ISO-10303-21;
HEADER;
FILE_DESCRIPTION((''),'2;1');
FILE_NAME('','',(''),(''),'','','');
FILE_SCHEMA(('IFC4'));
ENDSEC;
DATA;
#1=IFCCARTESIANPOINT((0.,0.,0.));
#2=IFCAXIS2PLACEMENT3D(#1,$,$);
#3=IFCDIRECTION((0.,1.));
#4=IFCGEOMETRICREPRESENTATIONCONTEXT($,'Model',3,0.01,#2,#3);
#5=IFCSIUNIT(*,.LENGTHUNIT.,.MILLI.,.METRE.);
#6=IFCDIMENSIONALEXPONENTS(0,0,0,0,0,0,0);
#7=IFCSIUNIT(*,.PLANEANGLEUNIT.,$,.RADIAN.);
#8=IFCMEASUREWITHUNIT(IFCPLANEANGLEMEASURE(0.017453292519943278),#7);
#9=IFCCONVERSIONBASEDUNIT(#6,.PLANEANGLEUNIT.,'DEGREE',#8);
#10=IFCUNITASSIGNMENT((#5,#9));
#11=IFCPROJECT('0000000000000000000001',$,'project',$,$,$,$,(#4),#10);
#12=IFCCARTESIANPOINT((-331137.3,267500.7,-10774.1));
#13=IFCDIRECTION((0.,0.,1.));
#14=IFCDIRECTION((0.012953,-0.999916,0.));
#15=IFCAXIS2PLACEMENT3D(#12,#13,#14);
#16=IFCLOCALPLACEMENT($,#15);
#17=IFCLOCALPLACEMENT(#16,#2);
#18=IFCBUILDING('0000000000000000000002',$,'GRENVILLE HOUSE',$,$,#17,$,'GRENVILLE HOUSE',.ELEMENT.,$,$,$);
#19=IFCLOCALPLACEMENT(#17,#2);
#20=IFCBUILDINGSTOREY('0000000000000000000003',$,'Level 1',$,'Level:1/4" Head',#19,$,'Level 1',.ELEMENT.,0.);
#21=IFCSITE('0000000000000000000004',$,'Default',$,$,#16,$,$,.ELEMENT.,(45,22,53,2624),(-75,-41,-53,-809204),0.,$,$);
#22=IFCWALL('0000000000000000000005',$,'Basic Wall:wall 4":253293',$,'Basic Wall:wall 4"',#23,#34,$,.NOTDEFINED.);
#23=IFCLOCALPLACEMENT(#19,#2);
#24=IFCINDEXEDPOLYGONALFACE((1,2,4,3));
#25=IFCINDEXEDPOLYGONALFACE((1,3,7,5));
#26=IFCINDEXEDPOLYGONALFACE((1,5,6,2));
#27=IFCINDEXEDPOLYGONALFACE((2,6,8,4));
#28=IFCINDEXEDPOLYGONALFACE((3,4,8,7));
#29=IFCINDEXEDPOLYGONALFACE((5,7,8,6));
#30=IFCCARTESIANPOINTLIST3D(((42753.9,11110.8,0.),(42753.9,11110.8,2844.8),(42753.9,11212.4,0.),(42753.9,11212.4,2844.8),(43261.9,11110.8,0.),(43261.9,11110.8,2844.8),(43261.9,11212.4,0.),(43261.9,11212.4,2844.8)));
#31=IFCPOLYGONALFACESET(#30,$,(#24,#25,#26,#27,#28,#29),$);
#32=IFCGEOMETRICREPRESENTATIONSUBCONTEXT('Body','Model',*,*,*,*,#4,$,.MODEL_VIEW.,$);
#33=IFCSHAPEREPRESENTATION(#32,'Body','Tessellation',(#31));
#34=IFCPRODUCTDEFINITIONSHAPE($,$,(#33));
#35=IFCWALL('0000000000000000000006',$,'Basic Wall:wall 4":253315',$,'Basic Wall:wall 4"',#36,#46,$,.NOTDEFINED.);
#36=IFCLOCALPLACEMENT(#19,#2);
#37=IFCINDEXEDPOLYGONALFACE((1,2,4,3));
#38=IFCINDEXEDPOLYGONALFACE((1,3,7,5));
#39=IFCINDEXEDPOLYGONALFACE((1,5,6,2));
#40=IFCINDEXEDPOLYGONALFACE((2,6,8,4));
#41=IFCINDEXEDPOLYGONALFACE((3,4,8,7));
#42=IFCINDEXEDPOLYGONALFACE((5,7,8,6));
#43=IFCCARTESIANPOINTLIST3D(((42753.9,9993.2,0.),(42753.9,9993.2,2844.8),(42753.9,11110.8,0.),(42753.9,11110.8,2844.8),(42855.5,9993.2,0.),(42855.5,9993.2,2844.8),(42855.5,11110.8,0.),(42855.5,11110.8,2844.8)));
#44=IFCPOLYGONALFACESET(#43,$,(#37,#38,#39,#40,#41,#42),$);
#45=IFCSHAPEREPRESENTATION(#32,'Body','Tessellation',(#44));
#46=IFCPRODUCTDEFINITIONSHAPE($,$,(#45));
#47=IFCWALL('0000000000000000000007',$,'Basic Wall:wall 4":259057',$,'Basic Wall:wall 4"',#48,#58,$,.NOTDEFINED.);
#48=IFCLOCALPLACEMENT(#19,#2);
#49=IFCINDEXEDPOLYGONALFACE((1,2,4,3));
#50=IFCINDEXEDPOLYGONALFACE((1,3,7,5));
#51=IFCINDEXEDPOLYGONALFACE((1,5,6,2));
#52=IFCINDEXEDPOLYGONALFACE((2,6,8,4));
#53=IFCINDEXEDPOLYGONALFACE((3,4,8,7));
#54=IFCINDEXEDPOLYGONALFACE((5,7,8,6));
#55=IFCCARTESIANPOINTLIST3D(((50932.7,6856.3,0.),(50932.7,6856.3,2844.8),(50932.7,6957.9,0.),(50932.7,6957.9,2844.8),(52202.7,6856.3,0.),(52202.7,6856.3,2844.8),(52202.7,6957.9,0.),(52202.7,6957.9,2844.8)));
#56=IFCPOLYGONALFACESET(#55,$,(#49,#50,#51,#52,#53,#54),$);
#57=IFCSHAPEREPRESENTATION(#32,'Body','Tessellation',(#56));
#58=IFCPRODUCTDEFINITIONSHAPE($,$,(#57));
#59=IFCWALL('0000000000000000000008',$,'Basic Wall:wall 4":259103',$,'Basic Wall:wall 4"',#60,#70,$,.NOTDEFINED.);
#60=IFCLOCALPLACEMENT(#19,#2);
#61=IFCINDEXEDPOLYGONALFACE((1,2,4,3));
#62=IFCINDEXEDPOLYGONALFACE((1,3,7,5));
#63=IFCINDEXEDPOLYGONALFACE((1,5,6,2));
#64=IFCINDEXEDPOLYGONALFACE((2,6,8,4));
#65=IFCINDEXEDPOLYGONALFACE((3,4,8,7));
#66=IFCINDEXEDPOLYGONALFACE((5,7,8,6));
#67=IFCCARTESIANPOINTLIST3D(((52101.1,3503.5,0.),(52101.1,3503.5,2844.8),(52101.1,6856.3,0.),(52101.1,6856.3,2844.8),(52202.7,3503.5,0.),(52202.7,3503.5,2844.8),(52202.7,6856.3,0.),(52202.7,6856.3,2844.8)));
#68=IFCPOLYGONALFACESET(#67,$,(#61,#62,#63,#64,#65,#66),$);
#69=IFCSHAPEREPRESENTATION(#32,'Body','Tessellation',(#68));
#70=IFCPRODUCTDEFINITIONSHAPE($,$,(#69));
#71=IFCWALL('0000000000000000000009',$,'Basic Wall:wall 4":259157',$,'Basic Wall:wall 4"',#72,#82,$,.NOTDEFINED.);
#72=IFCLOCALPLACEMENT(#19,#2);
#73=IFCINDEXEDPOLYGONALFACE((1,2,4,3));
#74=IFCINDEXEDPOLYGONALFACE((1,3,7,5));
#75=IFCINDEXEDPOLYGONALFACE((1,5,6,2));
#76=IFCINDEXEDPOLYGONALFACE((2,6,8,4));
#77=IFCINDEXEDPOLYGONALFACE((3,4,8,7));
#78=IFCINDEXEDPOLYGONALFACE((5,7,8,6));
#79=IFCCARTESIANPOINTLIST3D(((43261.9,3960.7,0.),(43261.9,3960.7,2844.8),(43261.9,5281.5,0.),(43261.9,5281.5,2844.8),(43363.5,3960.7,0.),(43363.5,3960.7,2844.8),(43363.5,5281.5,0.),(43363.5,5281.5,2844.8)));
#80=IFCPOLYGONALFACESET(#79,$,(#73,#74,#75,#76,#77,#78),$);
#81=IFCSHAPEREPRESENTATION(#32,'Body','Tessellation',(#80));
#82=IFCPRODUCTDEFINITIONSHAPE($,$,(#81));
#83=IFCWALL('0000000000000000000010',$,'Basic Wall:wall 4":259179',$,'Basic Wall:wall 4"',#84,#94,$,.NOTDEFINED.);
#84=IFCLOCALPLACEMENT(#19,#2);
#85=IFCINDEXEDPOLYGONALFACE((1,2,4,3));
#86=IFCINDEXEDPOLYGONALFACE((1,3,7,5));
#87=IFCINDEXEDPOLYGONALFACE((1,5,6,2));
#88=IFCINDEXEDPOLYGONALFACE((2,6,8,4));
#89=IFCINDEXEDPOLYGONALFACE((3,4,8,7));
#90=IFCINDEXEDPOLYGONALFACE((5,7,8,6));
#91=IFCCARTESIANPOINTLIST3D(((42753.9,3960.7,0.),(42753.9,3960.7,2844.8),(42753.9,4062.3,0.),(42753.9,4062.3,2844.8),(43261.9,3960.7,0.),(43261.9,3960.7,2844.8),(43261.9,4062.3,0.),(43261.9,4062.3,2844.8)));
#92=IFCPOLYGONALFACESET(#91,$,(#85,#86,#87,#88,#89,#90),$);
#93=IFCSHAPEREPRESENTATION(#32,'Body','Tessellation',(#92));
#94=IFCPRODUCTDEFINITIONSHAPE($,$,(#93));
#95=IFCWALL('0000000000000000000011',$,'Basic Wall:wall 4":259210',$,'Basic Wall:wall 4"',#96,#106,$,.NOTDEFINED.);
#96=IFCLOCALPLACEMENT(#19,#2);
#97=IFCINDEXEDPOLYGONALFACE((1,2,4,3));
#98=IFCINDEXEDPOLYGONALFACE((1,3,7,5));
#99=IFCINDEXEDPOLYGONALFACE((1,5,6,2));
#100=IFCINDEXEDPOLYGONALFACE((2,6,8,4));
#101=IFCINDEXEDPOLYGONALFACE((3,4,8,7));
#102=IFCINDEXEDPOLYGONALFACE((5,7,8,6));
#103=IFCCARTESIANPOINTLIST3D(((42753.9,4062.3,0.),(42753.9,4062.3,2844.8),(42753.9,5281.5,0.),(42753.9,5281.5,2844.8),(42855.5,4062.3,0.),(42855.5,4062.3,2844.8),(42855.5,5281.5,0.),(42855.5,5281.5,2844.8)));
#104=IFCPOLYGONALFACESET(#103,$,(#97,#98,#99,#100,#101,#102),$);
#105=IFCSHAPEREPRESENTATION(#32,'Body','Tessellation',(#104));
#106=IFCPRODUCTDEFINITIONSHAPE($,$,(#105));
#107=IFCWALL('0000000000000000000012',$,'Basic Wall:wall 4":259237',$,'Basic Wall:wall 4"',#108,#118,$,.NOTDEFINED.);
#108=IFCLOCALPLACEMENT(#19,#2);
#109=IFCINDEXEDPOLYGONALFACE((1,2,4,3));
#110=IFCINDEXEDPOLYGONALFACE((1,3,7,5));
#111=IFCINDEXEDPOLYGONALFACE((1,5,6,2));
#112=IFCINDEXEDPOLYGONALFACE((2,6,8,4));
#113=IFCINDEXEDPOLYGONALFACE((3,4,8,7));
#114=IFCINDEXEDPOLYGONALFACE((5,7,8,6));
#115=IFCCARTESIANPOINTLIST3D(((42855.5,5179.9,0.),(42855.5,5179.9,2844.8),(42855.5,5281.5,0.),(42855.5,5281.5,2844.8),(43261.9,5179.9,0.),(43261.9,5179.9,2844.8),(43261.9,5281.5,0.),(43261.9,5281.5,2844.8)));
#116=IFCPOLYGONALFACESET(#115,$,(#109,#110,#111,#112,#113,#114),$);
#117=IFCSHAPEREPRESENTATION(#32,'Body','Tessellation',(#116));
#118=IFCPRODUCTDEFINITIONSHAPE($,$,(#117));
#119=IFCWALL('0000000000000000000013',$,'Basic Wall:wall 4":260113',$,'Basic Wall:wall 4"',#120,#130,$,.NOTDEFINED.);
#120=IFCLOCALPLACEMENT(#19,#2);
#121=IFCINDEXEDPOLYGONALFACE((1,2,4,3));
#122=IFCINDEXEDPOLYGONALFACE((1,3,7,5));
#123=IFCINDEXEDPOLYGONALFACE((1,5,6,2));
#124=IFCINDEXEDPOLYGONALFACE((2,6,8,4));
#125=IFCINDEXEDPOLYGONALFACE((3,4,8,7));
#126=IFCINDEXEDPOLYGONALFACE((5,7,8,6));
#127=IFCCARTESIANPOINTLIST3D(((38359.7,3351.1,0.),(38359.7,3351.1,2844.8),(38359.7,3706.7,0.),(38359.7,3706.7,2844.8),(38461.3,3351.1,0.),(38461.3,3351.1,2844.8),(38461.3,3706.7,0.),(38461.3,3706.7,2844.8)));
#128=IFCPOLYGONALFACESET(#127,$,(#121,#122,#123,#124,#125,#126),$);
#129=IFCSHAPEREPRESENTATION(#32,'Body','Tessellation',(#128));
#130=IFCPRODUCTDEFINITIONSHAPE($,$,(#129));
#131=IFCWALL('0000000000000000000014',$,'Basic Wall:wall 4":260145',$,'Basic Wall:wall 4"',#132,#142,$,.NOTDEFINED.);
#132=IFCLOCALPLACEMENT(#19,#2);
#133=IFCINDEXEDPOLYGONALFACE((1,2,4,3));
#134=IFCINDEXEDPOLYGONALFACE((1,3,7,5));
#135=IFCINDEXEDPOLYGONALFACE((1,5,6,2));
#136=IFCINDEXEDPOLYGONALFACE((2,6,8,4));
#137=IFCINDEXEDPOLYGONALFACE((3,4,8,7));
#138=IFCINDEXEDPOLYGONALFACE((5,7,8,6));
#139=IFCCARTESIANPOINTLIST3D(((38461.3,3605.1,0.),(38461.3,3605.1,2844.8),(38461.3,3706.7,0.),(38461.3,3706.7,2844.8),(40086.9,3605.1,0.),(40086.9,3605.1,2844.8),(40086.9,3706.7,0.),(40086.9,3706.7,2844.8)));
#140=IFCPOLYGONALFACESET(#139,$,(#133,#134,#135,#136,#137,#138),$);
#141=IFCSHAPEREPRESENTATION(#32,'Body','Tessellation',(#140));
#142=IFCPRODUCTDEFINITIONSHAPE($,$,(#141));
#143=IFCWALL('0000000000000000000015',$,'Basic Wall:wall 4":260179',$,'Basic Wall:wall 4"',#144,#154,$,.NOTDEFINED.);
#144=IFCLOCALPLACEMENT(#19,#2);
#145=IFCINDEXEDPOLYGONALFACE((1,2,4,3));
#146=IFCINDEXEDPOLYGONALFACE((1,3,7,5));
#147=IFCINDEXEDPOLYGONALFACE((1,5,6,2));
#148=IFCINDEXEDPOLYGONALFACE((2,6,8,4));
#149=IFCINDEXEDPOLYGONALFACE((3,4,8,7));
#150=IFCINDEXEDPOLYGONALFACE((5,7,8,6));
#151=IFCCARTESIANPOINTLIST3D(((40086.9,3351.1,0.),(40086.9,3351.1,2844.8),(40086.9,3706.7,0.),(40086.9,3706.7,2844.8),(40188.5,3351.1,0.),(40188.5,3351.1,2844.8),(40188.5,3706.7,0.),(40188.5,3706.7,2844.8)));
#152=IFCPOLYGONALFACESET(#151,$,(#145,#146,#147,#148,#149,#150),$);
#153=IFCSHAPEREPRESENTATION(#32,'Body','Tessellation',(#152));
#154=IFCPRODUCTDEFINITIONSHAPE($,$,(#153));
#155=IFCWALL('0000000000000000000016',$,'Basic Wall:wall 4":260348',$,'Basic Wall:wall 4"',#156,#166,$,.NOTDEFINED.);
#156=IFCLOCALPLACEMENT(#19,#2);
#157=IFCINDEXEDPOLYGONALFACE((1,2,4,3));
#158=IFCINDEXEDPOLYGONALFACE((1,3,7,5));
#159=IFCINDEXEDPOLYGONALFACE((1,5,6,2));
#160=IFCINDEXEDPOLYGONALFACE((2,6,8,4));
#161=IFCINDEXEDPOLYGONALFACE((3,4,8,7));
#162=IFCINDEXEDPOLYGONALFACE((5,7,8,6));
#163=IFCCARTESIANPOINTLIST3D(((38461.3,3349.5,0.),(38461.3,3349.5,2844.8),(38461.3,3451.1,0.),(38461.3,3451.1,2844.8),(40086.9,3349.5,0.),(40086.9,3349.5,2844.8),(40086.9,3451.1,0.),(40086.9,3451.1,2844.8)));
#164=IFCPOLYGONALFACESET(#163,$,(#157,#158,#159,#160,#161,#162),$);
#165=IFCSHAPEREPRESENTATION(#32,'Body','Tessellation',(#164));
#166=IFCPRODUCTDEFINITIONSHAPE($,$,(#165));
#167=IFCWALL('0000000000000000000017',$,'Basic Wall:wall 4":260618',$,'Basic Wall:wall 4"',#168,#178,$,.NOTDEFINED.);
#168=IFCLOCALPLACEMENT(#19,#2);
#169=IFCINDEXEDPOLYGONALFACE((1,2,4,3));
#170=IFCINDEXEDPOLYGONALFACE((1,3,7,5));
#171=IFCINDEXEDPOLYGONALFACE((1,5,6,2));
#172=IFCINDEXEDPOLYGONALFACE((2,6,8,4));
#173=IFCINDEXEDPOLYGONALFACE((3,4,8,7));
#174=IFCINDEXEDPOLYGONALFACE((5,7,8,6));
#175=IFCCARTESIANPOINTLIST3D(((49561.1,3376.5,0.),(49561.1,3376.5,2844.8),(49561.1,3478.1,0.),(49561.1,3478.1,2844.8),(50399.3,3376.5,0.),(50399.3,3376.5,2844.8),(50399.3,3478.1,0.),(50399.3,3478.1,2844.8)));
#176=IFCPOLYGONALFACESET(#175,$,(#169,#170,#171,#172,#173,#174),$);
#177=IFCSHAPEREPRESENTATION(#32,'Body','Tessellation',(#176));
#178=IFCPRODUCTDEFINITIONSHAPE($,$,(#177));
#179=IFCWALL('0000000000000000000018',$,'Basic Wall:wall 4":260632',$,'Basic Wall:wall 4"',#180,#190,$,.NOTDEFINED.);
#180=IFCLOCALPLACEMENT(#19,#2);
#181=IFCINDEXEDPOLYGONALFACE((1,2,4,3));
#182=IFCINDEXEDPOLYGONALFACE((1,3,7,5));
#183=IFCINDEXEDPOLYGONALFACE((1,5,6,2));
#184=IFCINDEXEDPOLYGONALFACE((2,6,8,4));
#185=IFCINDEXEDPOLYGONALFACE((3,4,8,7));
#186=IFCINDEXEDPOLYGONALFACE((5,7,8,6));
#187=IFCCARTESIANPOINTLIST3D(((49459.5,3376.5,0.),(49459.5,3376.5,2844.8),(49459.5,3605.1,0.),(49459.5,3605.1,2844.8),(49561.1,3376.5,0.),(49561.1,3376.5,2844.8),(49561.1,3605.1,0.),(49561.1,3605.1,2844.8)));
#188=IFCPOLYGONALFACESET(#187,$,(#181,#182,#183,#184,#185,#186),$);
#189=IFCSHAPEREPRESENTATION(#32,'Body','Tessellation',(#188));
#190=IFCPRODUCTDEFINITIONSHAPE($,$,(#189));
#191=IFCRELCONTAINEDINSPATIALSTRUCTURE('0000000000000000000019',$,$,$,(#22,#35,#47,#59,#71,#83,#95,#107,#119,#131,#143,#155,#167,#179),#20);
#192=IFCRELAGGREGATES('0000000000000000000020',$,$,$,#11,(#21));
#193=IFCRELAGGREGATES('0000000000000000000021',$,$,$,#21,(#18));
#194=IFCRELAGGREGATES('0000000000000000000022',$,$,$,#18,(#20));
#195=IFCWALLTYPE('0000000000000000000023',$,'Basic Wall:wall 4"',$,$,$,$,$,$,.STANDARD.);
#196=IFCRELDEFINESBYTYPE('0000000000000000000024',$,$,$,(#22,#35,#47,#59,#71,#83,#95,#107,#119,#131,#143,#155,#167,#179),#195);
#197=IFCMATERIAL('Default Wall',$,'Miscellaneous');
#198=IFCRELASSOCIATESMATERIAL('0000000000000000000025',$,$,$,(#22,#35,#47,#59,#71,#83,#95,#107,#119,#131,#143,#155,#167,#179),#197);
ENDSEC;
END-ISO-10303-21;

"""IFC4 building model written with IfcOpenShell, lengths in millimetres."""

from ifc_helpers import new_model, entity, si_unit, converted_unit, direction, frame, origin, place, context, subcontext, project, spatial, indexed_curve, outline, extrude, material, type_object, element, save


model = new_model("IFC4")

# Units and contexts
model_context = context("Model", 3, precision=0.01, world=origin(), true_north=direction((0.0, 1.0)))
body_context = subcontext(model_context, "Body", "Model", "MODEL_VIEW")
ifc_project = project(units=[si_unit("LENGTHUNIT", "METRE", prefix="MILLI"), converted_unit("PLANEANGLEUNIT", "DEGREE", entity("IfcPlaneAngleMeasure", 0.017453292519943278), si_unit("PLANEANGLEUNIT", "RADIAN"), dimensions=[0, 0, 0, 0, 0, 0, 0])], contexts=[model_context])

# Site, building, storey
site_placement = place(None, frame((-331137.3, 267500.7, -10774.1), z_axis=(0.0, 0.0, 1.0), x_axis=(0.012953, -0.999916, 0.0)))
site = spatial("IfcSite", under=ifc_project, at=site_placement, Name="Default", CompositionType="ELEMENT", RefLatitude=(45, 22, 53, 2624), RefLongitude=(-75, -41, -53, -809204), RefElevation=0.0)
building_placement = place(site_placement, origin())
building = spatial("IfcBuilding", under=site, at=building_placement, Name="GRENVILLE HOUSE", LongName="GRENVILLE HOUSE", CompositionType="ELEMENT")
storey_placement = place(building_placement, origin())
storey = spatial("IfcBuildingStorey", under=building, at=storey_placement, Name="Level 1", ObjectType="Level:1/4\" Head", LongName="Level 1", CompositionType="ELEMENT", Elevation=0.0)

# Walls
ifc_material_1 = material(Name="Default Wall", Category="Miscellaneous")
wall_type_1 = type_object("IfcWallType", Name="Basic Wall:wall 4\"", PredefinedType="STANDARD")
wall_1_placement = place(storey_placement, frame((43261.9, 11161.6, 0.0), z_axis=(0.0, 0.0, 1.0), x_axis=(-1.0, 0.0, 0.0)))
element("IfcWall", 1, at=wall_1_placement, inside=storey, type_object=wall_type_1, material=ifc_material_1, Name="Basic Wall:wall 4\":253293", ObjectType="Basic Wall:wall 4\"", PredefinedType="NOTDEFINED", context=body_context, shape_type="SweptSolid", body=[
    extrude(outline(indexed_curve([(508.0, 50.8), (0.0, 50.8), (0.0, -50.8), (508.0, -50.8), (508.0, 50.8)], self_intersect=False)), origin(), (0.0, 0.0, 1.0), 2844.8),
])
wall_2_placement = place(storey_placement, frame((42804.7, 11110.8, 0.0), z_axis=(0.0, 0.0, 1.0), x_axis=(0.0, -1.0, 0.0)))
element("IfcWall", 2, at=wall_2_placement, inside=storey, type_object=wall_type_1, material=ifc_material_1, Name="Basic Wall:wall 4\":253315", ObjectType="Basic Wall:wall 4\"", PredefinedType="NOTDEFINED", context=body_context, shape_type="SweptSolid", body=[
    extrude(outline(indexed_curve([(1117.6, 50.8), (0.0, 50.8), (0.0, -50.8), (1117.6, -50.8), (1117.6, 50.8)], self_intersect=False)), origin(), (0.0, 0.0, 1.0), 2844.8),
])
wall_3_placement = place(storey_placement, frame((50932.7, 6907.1, 0.0)))
element("IfcWall", 3, at=wall_3_placement, inside=storey, type_object=wall_type_1, material=ifc_material_1, Name="Basic Wall:wall 4\":259057", ObjectType="Basic Wall:wall 4\"", PredefinedType="NOTDEFINED", context=body_context, shape_type="SweptSolid", body=[
    extrude(outline(indexed_curve([(1270.0, 50.8), (0.0, 50.8), (0.0, -50.8), (1270.0, -50.8), (1270.0, 50.8)], self_intersect=False)), origin(), (0.0, 0.0, 1.0), 2844.8),
])
wall_4_placement = place(storey_placement, frame((52151.9, 6856.3, 0.0), z_axis=(0.0, 0.0, 1.0), x_axis=(0.0, -1.0, 0.0)))
element("IfcWall", 4, at=wall_4_placement, inside=storey, type_object=wall_type_1, material=ifc_material_1, Name="Basic Wall:wall 4\":259103", ObjectType="Basic Wall:wall 4\"", PredefinedType="NOTDEFINED", context=body_context, shape_type="SweptSolid", body=[
    extrude(outline(indexed_curve([(3352.8, 50.8), (0.0, 50.8), (0.0, -50.8), (3352.8, -50.8), (3352.8, 50.8)], self_intersect=False)), origin(), (0.0, 0.0, 1.0), 2844.8),
])
wall_5_placement = place(storey_placement, frame((43312.7, 5281.5, 0.0), z_axis=(0.0, 0.0, 1.0), x_axis=(0.0, -1.0, 0.0)))
element("IfcWall", 5, at=wall_5_placement, inside=storey, type_object=wall_type_1, material=ifc_material_1, Name="Basic Wall:wall 4\":259157", ObjectType="Basic Wall:wall 4\"", PredefinedType="NOTDEFINED", context=body_context, shape_type="SweptSolid", body=[
    extrude(outline(indexed_curve([(1320.8, 50.8), (0.0, 50.8), (0.0, -50.8), (1320.8, -50.8), (1320.8, 50.8)], self_intersect=False)), origin(), (0.0, 0.0, 1.0), 2844.8),
])
wall_6_placement = place(storey_placement, frame((43261.9, 4011.5, 0.0), z_axis=(0.0, 0.0, 1.0), x_axis=(-1.0, 0.0, 0.0)))
element("IfcWall", 6, at=wall_6_placement, inside=storey, type_object=wall_type_1, material=ifc_material_1, Name="Basic Wall:wall 4\":259179", ObjectType="Basic Wall:wall 4\"", PredefinedType="NOTDEFINED", context=body_context, shape_type="SweptSolid", body=[
    extrude(outline(indexed_curve([(508.0, 50.8), (0.0, 50.8), (0.0, -50.8), (508.0, -50.8), (508.0, 50.8)], self_intersect=False)), origin(), (0.0, 0.0, 1.0), 2844.8),
])
wall_7_placement = place(storey_placement, frame((42804.7, 4062.3, 0.0), z_axis=(0.0, 0.0, 1.0), x_axis=(0.0, 1.0, 0.0)))
element("IfcWall", 7, at=wall_7_placement, inside=storey, type_object=wall_type_1, material=ifc_material_1, Name="Basic Wall:wall 4\":259210", ObjectType="Basic Wall:wall 4\"", PredefinedType="NOTDEFINED", context=body_context, shape_type="SweptSolid", body=[
    extrude(outline(indexed_curve([(1219.2, 50.8), (0.0, 50.8), (0.0, -50.8), (1219.2, -50.8), (1219.2, 50.8)], self_intersect=False)), origin(), (0.0, 0.0, 1.0), 2844.8),
])
wall_8_placement = place(storey_placement, frame((42855.5, 5230.7, 0.0)))
element("IfcWall", 8, at=wall_8_placement, inside=storey, type_object=wall_type_1, material=ifc_material_1, Name="Basic Wall:wall 4\":259237", ObjectType="Basic Wall:wall 4\"", PredefinedType="NOTDEFINED", context=body_context, shape_type="SweptSolid", body=[
    extrude(outline(indexed_curve([(406.4, 50.8), (0.0, 50.8), (0.0, -50.8), (406.4, -50.8), (406.4, 50.8)], self_intersect=False)), origin(), (0.0, 0.0, 1.0), 2844.8),
])
wall_9_placement = place(storey_placement, frame((38410.5, 3351.1, 0.0), z_axis=(0.0, 0.0, 1.0), x_axis=(0.0, 1.0, 0.0)))
element("IfcWall", 9, at=wall_9_placement, inside=storey, type_object=wall_type_1, material=ifc_material_1, Name="Basic Wall:wall 4\":260113", ObjectType="Basic Wall:wall 4\"", PredefinedType="NOTDEFINED", context=body_context, shape_type="SweptSolid", body=[
    extrude(outline(indexed_curve([(355.6, 50.8), (0.0, 50.8), (0.0, -50.8), (355.6, -50.8), (355.6, 50.8)], self_intersect=False)), origin(), (0.0, 0.0, 1.0), 2844.8),
])
wall_10_placement = place(storey_placement, frame((38461.3, 3655.9, 0.0)))
element("IfcWall", 10, at=wall_10_placement, inside=storey, type_object=wall_type_1, material=ifc_material_1, Name="Basic Wall:wall 4\":260145", ObjectType="Basic Wall:wall 4\"", PredefinedType="NOTDEFINED", context=body_context, shape_type="SweptSolid", body=[
    extrude(outline(indexed_curve([(1625.6, 50.8), (0.0, 50.8), (0.0, -50.8), (1625.6, -50.8), (1625.6, 50.8)], self_intersect=False)), origin(), (0.0, 0.0, 1.0), 2844.8),
])
wall_11_placement = place(storey_placement, frame((40137.7, 3706.7, 0.0), z_axis=(0.0, 0.0, 1.0), x_axis=(0.0, -1.0, 0.0)))
element("IfcWall", 11, at=wall_11_placement, inside=storey, type_object=wall_type_1, material=ifc_material_1, Name="Basic Wall:wall 4\":260179", ObjectType="Basic Wall:wall 4\"", PredefinedType="NOTDEFINED", context=body_context, shape_type="SweptSolid", body=[
    extrude(outline(indexed_curve([(355.6, 50.8), (0.0, 50.8), (0.0, -50.8), (355.6, -50.8), (355.6, 50.8)], self_intersect=False)), origin(), (0.0, 0.0, 1.0), 2844.8),
])
wall_12_placement = place(storey_placement, frame((38461.3, 3400.3, 0.0)))
element("IfcWall", 12, at=wall_12_placement, inside=storey, type_object=wall_type_1, material=ifc_material_1, Name="Basic Wall:wall 4\":260348", ObjectType="Basic Wall:wall 4\"", PredefinedType="NOTDEFINED", context=body_context, shape_type="SweptSolid", body=[
    extrude(outline(indexed_curve([(1625.6, 50.8), (0.0, 50.8), (0.0, -50.8), (1625.6, -50.8), (1625.6, 50.8)], self_intersect=False)), origin(), (0.0, 0.0, 1.0), 2844.8),
])
wall_13_placement = place(storey_placement, frame((50399.3, 3427.3, 0.0), z_axis=(0.0, 0.0, 1.0), x_axis=(-1.0, 0.0, 0.0)))
element("IfcWall", 13, at=wall_13_placement, inside=storey, type_object=wall_type_1, material=ifc_material_1, Name="Basic Wall:wall 4\":260618", ObjectType="Basic Wall:wall 4\"", PredefinedType="NOTDEFINED", context=body_context, shape_type="SweptSolid", body=[
    extrude(outline(indexed_curve([(838.2, 50.8), (0.0, 50.8), (0.0, -50.8), (838.2, -50.8), (838.2, 50.8)], self_intersect=False)), origin(), (0.0, 0.0, 1.0), 2844.8),
])
wall_14_placement = place(storey_placement, frame((49510.3, 3376.5, 0.0), z_axis=(0.0, 0.0, 1.0), x_axis=(0.0, 1.0, 0.0)))
element("IfcWall", 14, at=wall_14_placement, inside=storey, type_object=wall_type_1, material=ifc_material_1, Name="Basic Wall:wall 4\":260632", ObjectType="Basic Wall:wall 4\"", PredefinedType="NOTDEFINED", context=body_context, shape_type="SweptSolid", body=[
    extrude(outline(indexed_curve([(228.6, 50.8), (0.0, 50.8), (0.0, -50.8), (228.6, -50.8), (228.6, 50.8)], self_intersect=False)), origin(), (0.0, 0.0, 1.0), 2844.8),
])

save(model, "model.ifc")
